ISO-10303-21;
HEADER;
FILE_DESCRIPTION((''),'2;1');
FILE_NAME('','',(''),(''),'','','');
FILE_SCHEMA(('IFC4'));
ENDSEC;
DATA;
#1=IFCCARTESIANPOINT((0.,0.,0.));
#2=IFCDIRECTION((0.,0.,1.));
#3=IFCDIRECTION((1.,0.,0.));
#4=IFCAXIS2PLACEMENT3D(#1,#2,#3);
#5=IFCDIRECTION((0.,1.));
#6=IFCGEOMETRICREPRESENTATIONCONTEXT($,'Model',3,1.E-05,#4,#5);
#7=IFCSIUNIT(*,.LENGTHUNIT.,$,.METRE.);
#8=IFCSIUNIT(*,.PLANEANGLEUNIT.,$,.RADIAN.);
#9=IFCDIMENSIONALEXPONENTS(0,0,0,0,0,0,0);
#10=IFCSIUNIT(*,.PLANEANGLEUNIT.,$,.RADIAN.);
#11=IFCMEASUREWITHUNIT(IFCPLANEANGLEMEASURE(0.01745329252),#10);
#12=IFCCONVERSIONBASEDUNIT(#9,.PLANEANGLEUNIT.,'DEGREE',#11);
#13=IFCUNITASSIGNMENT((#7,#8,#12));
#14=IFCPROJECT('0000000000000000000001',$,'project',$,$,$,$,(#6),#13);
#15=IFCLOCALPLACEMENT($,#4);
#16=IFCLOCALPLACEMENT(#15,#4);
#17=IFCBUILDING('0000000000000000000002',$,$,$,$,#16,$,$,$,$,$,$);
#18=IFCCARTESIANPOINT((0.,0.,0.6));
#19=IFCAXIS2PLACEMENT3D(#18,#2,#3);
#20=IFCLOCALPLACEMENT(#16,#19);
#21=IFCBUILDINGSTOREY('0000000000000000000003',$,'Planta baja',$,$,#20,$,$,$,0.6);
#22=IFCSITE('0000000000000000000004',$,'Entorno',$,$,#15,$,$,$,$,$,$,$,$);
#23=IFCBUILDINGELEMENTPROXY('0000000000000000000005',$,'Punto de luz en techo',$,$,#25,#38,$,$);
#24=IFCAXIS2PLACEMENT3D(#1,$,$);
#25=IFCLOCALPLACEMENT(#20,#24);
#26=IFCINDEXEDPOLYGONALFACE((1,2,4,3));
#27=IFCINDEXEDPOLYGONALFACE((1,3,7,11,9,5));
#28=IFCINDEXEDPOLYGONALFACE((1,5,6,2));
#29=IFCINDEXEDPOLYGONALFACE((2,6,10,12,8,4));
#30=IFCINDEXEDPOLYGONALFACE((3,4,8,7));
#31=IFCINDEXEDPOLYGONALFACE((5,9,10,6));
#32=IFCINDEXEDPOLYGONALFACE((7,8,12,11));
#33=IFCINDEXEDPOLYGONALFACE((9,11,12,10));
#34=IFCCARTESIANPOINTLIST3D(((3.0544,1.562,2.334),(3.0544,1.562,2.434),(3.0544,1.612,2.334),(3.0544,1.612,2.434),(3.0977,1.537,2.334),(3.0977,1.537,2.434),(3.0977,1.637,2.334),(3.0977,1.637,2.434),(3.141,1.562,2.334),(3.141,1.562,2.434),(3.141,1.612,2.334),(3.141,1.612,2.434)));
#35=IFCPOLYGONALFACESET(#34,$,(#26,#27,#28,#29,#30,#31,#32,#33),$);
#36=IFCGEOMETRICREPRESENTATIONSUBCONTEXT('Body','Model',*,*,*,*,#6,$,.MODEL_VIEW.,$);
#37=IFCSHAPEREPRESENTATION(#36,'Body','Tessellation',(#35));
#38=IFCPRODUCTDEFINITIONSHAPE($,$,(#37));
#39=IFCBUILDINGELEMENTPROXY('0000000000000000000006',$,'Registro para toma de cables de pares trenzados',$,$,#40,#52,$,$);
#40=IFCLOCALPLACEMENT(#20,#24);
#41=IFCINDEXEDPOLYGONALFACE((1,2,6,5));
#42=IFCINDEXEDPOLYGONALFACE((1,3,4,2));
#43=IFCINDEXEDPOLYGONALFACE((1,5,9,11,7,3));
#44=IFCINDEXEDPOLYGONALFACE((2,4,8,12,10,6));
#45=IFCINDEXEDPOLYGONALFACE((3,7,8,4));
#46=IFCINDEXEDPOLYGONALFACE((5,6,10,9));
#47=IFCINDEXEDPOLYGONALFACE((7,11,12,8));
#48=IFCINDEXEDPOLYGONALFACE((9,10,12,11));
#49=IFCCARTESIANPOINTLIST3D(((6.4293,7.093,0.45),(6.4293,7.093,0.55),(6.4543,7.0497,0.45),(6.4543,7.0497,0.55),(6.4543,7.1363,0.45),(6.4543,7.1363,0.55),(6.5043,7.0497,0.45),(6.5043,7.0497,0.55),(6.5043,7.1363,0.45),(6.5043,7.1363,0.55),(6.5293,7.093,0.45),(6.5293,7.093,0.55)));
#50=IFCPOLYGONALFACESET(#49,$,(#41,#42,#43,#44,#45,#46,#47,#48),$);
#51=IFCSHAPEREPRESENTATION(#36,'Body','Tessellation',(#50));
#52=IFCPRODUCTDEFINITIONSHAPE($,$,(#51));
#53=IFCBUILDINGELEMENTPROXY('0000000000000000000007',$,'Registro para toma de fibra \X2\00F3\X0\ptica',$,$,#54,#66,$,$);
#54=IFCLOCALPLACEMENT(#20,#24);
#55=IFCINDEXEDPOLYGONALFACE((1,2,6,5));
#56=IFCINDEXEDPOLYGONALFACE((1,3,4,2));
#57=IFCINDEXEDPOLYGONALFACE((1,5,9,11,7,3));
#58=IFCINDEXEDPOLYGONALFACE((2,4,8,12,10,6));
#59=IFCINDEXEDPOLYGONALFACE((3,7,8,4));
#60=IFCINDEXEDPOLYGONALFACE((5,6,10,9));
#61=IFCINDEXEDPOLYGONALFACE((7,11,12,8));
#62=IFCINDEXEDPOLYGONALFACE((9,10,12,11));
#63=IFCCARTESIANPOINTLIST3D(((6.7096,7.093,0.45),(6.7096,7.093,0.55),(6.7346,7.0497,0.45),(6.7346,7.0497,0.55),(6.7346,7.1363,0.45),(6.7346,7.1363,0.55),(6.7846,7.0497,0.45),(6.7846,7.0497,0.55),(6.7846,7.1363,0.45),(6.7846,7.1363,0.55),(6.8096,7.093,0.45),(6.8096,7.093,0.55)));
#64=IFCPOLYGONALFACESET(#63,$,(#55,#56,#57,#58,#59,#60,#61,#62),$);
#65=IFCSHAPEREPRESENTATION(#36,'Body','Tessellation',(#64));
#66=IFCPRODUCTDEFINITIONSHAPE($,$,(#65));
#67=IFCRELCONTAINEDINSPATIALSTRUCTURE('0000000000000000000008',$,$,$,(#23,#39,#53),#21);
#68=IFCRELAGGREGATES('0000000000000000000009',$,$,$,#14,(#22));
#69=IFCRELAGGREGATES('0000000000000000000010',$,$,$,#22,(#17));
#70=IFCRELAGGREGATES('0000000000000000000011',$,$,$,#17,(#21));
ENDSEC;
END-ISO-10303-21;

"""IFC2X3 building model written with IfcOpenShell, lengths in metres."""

from ifc_helpers import new_model, entity, si_unit, converted_unit, direction, frame, origin_with_axes, place, context, subcontext, project, spatial, polyline, outline, extrude, source, transform, mapped, element, save


model = new_model("IFC2X3")

# Units and contexts
model_context = context("Model", 3, precision=1e-05, world=origin_with_axes(), true_north=direction((0.0, 1.0)))
body_context = subcontext(model_context, "Body", "Model", "MODEL_VIEW")
ifc_project = project(units=[si_unit("LENGTHUNIT", "METRE"), si_unit("PLANEANGLEUNIT", "RADIAN"), converted_unit("PLANEANGLEUNIT", "DEGREE", entity("IfcPlaneAngleMeasure", 0.01745329252), si_unit("PLANEANGLEUNIT", "RADIAN"), dimensions=[0, 0, 0, 0, 0, 0, 0])], contexts=[model_context])

# Site, building, storey
site_placement = place(None, origin_with_axes())
site = spatial("IfcSite", under=ifc_project, at=site_placement, Name="Entorno")
building_placement = place(site_placement, origin_with_axes())
building = spatial("IfcBuilding", under=site, at=building_placement)
storey_placement = place(building_placement, frame((0.0, 0.0, 0.6), z_axis=(0.0, 0.0, 1.0), x_axis=(1.0, 0.0, 0.0)))
storey = spatial("IfcBuildingStorey", under=building, at=storey_placement, Name="Planta baja", Elevation=0.6)

# Building element proxies
shared_shape_1 = source(origin_with_axes(), body_context, "Body", "SolidModel", [
    extrude(outline(polyline([(0.05, 0.0), (0.025, 0.0433), (-0.025, 0.0433), (-0.05, 0.0), (-0.025, -0.0433), (0.025, -0.0433), (0.05, 0.0)])), frame((0.0, 0.0, -0.05), z_axis=(0.0, 0.0, 1.0), x_axis=(1.0, 0.0, 0.0)), (0.0, 0.0, 1.0), 0.1),
])
proxy_1_placement = place(storey_placement, frame((0.0, 0.0, -0.6), z_axis=(0.0, 0.0, 1.0), x_axis=(1.0, 0.0, 0.0)))
element("IfcBuildingElementProxy", 1, at=proxy_1_placement, inside=storey, Name="Punto de luz en techo", context=body_context, shape_type="Brep", body=[
    mapped(shared_shape_1, transform((3.0977, 1.587, 2.984), x_axis=(0.0, -1.0, 0.0), y_axis=(1.0, 0.0, 0.0), z_axis=(0.0, 0.0, 1.0))),
])
shared_shape_2 = source(origin_with_axes(), body_context, "Body", "SolidModel", [
    extrude(outline(polyline([(0.05, 0.0), (0.025, 0.0433), (-0.025, 0.0433), (-0.05, 0.0), (-0.025, -0.0433), (0.025, -0.0433), (0.05, 0.0)])), frame((0.0, 0.0, -0.05), z_axis=(0.0, 0.0, 1.0), x_axis=(1.0, 0.0, 0.0)), (0.0, 0.0, 1.0), 0.1),
])
proxy_2_placement = place(storey_placement, frame((0.0, 0.0, -0.6), z_axis=(0.0, 0.0, 1.0), x_axis=(1.0, 0.0, 0.0)))
element("IfcBuildingElementProxy", 2, at=proxy_2_placement, inside=storey, Name="Registro para toma de cables de pares trenzados", context=body_context, shape_type="Brep", body=[
    mapped(shared_shape_2, transform((6.4793, 7.093, 1.1), x_axis=(1.0, 0.0, 0.0), y_axis=(0.0, 1.0, 0.0), z_axis=(0.0, 0.0, 1.0))),
])
shared_shape_3 = source(origin_with_axes(), body_context, "Body", "SolidModel", [
    extrude(outline(polyline([(0.05, 0.0), (0.025, 0.0433), (-0.025, 0.0433), (-0.05, 0.0), (-0.025, -0.0433), (0.025, -0.0433), (0.05, 0.0)])), frame((0.0, 0.0, -0.05), z_axis=(0.0, 0.0, 1.0), x_axis=(1.0, 0.0, 0.0)), (0.0, 0.0, 1.0), 0.1),
])
proxy_3_placement = place(storey_placement, frame((0.0, 0.0, -0.6), z_axis=(0.0, 0.0, 1.0), x_axis=(1.0, 0.0, 0.0)))
element("IfcBuildingElementProxy", 3, at=proxy_3_placement, inside=storey, Name="Registro para toma de fibra óptica", context=body_context, shape_type="Brep", body=[
    mapped(shared_shape_3, transform((6.7596, 7.093, 1.1), x_axis=(1.0, 0.0, 0.0), y_axis=(0.0, 1.0, 0.0), z_axis=(0.0, 0.0, 1.0))),
])

save(model, "model.ifc")
